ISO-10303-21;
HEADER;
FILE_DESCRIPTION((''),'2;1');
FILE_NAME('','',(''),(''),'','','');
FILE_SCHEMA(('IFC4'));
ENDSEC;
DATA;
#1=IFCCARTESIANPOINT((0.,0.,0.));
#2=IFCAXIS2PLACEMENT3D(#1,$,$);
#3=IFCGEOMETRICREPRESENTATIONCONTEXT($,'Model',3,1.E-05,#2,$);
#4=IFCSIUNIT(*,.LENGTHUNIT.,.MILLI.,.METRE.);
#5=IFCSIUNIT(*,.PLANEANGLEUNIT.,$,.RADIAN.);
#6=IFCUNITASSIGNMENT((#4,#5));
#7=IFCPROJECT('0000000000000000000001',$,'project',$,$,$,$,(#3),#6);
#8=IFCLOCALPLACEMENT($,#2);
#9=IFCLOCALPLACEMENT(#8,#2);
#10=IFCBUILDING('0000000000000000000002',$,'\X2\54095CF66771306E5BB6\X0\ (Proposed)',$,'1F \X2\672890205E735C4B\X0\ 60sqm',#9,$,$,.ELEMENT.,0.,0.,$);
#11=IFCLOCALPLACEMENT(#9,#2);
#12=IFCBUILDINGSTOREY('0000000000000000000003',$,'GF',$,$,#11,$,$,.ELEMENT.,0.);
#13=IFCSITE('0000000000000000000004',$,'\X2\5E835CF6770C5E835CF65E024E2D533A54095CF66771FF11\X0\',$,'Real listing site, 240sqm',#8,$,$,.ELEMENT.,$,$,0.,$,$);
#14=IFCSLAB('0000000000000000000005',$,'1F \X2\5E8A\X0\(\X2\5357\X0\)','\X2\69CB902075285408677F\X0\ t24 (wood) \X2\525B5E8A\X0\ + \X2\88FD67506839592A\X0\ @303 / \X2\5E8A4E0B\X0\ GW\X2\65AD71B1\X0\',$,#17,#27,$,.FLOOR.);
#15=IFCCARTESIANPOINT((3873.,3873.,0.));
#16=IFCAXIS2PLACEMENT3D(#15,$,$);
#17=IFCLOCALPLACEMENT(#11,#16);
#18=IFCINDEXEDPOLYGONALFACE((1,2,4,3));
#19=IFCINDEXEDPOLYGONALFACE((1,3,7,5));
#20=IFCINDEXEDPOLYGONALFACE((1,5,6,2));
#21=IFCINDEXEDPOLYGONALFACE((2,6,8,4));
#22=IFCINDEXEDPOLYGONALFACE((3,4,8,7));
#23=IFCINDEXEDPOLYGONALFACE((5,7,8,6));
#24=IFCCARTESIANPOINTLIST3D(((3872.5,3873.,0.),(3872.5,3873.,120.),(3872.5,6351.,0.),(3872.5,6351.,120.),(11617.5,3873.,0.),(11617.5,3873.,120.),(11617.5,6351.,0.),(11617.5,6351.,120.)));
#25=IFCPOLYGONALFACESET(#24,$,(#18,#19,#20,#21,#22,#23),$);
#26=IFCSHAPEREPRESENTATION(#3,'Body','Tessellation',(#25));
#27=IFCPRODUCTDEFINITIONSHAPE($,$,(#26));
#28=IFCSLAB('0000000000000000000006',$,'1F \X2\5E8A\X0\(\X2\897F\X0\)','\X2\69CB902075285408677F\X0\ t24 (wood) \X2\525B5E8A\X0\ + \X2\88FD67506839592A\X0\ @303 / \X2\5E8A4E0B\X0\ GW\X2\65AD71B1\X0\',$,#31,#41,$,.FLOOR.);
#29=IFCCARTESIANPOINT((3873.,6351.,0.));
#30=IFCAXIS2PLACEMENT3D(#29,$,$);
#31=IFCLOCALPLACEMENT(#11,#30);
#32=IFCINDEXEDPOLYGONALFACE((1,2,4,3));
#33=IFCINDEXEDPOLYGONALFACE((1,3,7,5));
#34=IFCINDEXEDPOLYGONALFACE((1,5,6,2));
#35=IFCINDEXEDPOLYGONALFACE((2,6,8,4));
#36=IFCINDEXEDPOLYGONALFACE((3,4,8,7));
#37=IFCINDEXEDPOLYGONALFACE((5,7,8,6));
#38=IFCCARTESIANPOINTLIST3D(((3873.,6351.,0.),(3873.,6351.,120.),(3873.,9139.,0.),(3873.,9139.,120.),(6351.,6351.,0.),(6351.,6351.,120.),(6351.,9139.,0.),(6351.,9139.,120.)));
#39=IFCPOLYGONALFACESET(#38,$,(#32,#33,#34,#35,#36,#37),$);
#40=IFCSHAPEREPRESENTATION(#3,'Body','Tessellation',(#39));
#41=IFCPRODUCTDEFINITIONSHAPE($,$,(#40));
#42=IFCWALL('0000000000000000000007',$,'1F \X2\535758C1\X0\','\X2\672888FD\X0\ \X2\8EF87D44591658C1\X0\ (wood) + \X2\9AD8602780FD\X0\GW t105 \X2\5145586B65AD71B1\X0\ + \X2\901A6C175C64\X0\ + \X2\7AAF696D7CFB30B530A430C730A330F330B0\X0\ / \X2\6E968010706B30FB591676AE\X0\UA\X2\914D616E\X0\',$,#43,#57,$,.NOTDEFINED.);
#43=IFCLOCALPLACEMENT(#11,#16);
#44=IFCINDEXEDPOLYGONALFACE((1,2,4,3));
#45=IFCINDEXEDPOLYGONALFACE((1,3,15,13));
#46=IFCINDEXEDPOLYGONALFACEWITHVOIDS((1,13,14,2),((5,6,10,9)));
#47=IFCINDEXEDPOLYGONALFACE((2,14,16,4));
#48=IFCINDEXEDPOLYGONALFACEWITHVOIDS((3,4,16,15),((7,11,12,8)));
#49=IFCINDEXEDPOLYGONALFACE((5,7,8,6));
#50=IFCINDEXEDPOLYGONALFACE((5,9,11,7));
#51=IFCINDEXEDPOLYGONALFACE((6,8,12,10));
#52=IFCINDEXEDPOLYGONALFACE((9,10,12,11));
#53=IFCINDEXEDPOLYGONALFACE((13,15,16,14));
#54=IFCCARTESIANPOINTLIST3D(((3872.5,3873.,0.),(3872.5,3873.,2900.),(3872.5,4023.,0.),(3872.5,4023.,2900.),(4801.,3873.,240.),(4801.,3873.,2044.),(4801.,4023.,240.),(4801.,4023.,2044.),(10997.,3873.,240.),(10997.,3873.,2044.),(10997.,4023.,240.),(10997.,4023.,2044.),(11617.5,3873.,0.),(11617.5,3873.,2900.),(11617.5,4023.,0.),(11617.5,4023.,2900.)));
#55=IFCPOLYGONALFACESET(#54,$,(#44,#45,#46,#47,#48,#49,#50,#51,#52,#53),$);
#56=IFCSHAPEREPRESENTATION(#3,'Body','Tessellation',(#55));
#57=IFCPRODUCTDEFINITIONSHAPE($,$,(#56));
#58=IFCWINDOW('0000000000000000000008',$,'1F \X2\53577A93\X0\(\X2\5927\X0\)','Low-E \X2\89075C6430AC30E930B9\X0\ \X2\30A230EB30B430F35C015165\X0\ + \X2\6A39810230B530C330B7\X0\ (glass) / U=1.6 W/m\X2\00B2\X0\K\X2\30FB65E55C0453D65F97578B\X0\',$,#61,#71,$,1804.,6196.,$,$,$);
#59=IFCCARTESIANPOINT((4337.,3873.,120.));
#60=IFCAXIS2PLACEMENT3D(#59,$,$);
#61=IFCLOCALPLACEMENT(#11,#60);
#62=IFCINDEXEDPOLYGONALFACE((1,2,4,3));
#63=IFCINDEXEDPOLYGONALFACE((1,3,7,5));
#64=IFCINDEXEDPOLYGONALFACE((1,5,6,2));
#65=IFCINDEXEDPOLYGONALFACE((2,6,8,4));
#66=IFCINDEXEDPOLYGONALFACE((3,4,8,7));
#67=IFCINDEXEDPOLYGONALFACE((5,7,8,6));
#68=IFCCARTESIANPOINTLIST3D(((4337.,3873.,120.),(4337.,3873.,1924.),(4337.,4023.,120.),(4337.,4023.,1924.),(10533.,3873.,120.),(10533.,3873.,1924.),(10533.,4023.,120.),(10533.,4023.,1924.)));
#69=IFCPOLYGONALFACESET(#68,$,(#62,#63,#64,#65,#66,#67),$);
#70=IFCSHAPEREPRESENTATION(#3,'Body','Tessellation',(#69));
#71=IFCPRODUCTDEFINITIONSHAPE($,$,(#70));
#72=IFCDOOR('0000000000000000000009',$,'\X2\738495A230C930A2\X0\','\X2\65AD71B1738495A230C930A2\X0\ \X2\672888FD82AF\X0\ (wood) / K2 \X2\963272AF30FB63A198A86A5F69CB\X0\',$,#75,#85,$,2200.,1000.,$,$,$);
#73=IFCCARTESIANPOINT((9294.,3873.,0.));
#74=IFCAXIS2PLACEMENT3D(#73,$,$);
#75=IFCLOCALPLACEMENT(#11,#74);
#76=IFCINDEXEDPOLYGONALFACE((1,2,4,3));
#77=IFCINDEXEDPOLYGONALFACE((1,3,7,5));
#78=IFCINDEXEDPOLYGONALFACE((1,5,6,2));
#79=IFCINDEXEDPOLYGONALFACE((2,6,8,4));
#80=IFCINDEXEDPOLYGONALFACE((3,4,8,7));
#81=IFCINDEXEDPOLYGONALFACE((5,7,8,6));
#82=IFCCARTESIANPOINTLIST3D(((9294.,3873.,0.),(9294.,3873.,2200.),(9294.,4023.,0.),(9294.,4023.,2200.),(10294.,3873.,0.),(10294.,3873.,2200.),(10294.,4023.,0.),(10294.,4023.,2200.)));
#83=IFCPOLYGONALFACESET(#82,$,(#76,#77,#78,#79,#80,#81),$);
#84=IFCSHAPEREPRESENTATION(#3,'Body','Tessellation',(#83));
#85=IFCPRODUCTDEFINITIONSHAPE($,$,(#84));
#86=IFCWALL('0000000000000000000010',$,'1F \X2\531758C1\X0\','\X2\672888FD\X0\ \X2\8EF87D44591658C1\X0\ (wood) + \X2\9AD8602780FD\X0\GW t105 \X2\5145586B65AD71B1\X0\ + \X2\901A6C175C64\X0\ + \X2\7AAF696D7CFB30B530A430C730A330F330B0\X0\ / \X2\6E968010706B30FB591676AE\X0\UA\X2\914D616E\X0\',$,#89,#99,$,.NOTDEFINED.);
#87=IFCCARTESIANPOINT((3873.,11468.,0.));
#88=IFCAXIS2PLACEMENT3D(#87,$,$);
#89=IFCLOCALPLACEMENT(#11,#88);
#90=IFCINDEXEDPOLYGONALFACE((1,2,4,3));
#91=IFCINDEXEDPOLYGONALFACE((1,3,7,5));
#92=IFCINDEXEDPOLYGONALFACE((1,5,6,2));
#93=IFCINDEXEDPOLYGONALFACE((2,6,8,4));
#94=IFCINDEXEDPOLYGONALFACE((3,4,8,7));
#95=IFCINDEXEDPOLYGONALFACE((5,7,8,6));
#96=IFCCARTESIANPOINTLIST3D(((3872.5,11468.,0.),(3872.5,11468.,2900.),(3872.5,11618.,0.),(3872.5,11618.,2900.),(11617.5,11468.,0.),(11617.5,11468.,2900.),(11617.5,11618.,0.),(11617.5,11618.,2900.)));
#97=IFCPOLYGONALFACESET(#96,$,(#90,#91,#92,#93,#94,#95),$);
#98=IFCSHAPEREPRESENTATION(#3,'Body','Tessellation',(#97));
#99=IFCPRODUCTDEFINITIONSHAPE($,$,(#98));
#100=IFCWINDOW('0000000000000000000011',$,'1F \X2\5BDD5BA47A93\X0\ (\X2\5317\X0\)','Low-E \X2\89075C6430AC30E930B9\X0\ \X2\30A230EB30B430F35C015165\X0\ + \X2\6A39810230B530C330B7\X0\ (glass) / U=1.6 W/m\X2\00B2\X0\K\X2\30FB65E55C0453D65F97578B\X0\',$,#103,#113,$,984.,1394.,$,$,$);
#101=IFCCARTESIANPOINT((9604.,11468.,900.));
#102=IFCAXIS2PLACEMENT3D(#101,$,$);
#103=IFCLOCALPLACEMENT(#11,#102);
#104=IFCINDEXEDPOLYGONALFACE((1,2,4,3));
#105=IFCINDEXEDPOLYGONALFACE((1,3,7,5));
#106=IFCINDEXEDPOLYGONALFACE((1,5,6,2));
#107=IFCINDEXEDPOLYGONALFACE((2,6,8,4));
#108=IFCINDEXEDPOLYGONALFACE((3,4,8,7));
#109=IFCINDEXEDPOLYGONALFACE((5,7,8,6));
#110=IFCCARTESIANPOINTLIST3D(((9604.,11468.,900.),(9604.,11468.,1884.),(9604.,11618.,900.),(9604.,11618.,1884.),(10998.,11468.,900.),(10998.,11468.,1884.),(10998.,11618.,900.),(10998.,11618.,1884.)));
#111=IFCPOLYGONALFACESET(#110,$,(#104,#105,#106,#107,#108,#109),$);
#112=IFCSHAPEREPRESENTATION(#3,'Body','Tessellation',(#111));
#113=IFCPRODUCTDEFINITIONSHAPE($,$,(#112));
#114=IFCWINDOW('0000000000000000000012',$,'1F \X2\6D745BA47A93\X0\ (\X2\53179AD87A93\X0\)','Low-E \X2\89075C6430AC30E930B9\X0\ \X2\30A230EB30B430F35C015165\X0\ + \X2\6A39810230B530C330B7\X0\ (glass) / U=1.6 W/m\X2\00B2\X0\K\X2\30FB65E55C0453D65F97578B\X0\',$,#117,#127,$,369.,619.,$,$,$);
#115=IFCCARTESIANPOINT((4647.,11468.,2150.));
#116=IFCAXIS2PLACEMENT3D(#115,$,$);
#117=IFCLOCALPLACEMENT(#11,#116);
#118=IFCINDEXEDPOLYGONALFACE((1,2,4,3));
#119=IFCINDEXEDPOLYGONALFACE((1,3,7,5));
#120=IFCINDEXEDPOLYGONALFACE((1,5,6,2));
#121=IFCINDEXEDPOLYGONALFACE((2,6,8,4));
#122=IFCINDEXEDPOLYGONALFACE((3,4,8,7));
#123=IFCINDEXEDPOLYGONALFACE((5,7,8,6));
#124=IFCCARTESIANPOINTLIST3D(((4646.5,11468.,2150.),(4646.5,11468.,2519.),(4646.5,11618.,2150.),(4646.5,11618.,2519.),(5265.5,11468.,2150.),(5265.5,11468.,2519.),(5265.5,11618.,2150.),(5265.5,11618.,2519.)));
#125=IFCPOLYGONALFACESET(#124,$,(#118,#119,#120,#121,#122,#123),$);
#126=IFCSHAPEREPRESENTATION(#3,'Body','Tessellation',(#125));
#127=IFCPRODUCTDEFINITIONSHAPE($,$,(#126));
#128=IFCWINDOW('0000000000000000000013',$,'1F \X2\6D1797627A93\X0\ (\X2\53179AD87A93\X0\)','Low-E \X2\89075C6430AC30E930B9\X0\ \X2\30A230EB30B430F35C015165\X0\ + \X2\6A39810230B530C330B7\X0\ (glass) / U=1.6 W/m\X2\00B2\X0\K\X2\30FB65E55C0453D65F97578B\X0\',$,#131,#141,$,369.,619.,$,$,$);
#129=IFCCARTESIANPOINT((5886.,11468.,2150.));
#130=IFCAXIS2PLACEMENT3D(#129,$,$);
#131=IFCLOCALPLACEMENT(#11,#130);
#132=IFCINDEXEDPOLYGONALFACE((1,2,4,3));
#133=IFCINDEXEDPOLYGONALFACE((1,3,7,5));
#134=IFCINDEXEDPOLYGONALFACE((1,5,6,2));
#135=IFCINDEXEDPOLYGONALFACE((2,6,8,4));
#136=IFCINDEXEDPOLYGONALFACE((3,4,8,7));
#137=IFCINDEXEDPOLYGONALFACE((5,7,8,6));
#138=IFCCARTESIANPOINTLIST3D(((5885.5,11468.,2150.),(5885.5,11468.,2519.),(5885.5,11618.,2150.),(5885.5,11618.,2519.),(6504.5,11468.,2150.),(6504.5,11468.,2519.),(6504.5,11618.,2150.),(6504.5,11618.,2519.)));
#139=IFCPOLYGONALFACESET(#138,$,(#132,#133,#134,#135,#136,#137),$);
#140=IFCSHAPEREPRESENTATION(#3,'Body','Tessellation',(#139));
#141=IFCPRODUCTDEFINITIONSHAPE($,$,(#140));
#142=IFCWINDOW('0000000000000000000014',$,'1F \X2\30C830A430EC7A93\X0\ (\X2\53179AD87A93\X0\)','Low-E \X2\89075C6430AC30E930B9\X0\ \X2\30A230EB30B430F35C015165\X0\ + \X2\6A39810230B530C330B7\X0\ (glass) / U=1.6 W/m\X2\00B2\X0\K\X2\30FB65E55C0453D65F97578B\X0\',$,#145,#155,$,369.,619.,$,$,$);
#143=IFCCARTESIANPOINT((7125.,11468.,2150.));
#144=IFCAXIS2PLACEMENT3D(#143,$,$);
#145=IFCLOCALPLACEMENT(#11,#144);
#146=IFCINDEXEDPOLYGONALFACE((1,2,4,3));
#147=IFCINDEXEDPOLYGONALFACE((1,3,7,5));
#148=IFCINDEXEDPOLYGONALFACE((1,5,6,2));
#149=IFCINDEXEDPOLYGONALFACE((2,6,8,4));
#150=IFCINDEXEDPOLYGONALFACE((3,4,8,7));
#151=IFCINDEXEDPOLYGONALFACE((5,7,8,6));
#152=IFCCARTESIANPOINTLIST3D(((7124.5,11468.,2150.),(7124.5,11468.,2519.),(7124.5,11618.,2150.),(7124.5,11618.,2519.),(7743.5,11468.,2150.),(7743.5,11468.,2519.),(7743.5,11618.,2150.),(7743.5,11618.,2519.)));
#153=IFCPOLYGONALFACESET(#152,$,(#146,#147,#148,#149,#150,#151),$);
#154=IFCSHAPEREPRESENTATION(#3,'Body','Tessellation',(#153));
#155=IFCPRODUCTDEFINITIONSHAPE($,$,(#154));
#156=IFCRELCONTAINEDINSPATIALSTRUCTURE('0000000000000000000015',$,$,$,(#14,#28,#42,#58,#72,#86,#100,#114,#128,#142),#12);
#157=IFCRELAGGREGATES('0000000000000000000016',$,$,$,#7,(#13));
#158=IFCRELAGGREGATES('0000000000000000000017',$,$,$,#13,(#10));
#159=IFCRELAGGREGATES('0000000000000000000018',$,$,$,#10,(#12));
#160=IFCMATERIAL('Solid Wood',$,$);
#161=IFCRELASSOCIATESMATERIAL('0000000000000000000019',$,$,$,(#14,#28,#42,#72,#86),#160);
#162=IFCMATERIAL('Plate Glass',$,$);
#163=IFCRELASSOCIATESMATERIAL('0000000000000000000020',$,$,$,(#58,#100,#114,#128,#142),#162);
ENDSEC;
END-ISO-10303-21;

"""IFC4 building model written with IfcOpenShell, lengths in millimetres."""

from ifc_helpers import new_model, si_unit, frame, frame_2d, origin, place, context, project, spatial, rectangle, extrude, material, element, fill, save


model = new_model("IFC4")

# Units and contexts
model_context = context("Model", 3, precision=1e-05, world=origin())
ifc_project = project(units=[si_unit("LENGTHUNIT", "METRE", prefix="MILLI"), si_unit("PLANEANGLEUNIT", "RADIAN")], contexts=[model_context])

# Site, building, storey
site_placement = place(None, origin())
site = spatial("IfcSite", under=ifc_project, at=site_placement, Name="広島県広島市中区吉島東１", ObjectType="Real listing site, 240sqm", CompositionType="ELEMENT", RefElevation=0.0)
building_placement = place(site_placement, origin())
building = spatial("IfcBuilding", under=site, at=building_placement, Name="吉島東の家 (Proposed)", ObjectType="1F 木造平屋 60sqm", CompositionType="ELEMENT", ElevationOfRefHeight=0.0, ElevationOfTerrain=0.0)
storey_placement = place(building_placement, origin())
storey = spatial("IfcBuildingStorey", under=building, at=storey_placement, Name="GF", CompositionType="ELEMENT", Elevation=0.0)

# Slabs
ifc_material_1 = material(Name="Solid Wood")
slab_1_placement = place(storey_placement, frame((3873.0, 3873.0, 0.0)))
element("IfcSlab", 1, at=slab_1_placement, inside=storey, material=ifc_material_1, Name="1F 床(南)", Description="構造用合板 t24 (wood) 剛床 + 製材根太 @303 / 床下 GW断熱", PredefinedType="FLOOR", context=model_context, shape_type="SweptSolid", body=[
    extrude(rectangle(XDim=7745.0, YDim=2478.0, at=frame_2d((3872.0, 1239.0))), frame((3873.0, 3873.0, 0.0)), (0.0, 0.0, 1.0), 120.0),
])
slab_2_placement = place(storey_placement, frame((3873.0, 6351.0, 0.0)))
element("IfcSlab", 2, at=slab_2_placement, inside=storey, material=ifc_material_1, Name="1F 床(西)", Description="構造用合板 t24 (wood) 剛床 + 製材根太 @303 / 床下 GW断熱", PredefinedType="FLOOR", context=model_context, shape_type="SweptSolid", body=[
    extrude(rectangle(XDim=2478.0, YDim=2788.0, at=frame_2d((1239.0, 1394.0))), frame((3873.0, 6351.0, 0.0)), (0.0, 0.0, 1.0), 120.0),
])

# Wall, openings, window, door
wall_1_placement = place(storey_placement, frame((3873.0, 3873.0, 0.0)))
wall_1 = element("IfcWall", 3, at=wall_1_placement, inside=storey, material=ifc_material_1, Name="1F 南壁", Description="木製 軸組外壁 (wood) + 高性能GW t105 充填断熱 + 通気層 + 窯業系サイディング / 準耐火・外皮UA配慮", PredefinedType="NOTDEFINED", context=model_context, shape_type="SweptSolid", body=[
    extrude(rectangle(XDim=7745.0, YDim=150.0, at=frame_2d((3872.0, 75.0))), frame((3873.0, 3873.0, 0.0)), (0.0, 0.0, 1.0), 2900.0),
])
opening_1_placement = place(storey_placement, frame((4337.0, 3873.0, 120.0)))
opening_1 = element("IfcOpeningElement", 4, at=opening_1_placement, cuts=wall_1, PredefinedType="NOTDEFINED", context=model_context, shape_type="SweptSolid", body=[
    extrude(rectangle(XDim=6196.0, YDim=150.0, at=frame_2d((3098.0, 75.0))), frame((4337.0, 3873.0, 120.0)), (0.0, 0.0, 1.0), 1804.0),
])
opening_2_placement = place(storey_placement, frame((9294.0, 3873.0, 0.0)))
opening_2 = element("IfcOpeningElement", 5, at=opening_2_placement, cuts=wall_1, PredefinedType="NOTDEFINED", context=model_context, shape_type="SweptSolid", body=[
    extrude(rectangle(XDim=1000.0, YDim=150.0, at=frame_2d((500.0, 75.0))), frame((9294.0, 3873.0, 0.0)), (0.0, 0.0, 1.0), 2200.0),
])
ifc_material_2 = material(Name="Plate Glass")
window_1_placement = place(storey_placement, frame((4337.0, 3873.0, 120.0)))
window_1 = element("IfcWindow", 6, at=window_1_placement, inside=storey, material=ifc_material_2, Name="1F 南窓(大)", Description="Low-E 複層ガラス アルゴン封入 + 樹脂サッシ (glass) / U=1.6 W/m²K・日射取得型", OverallHeight=1804.0, OverallWidth=6196.0, context=model_context, shape_type="SweptSolid", body=[
    extrude(rectangle(XDim=6196.0, YDim=150.0, at=frame_2d((3098.0, 75.0))), frame((4337.0, 3873.0, 120.0)), (0.0, 0.0, 1.0), 1804.0),
])
fill(opening_1, window_1)
door_1_placement = place(storey_placement, frame((9294.0, 3873.0, 0.0)))
door_1 = element("IfcDoor", 7, at=door_1_placement, inside=storey, material=ifc_material_1, Name="玄関ドア", Description="断熱玄関ドア 木製芯 (wood) / K2 防犯・採風機構", OverallHeight=2200.0, OverallWidth=1000.0, context=model_context, shape_type="SweptSolid", body=[
    extrude(rectangle(XDim=1000.0, YDim=150.0, at=frame_2d((500.0, 75.0))), frame((9294.0, 3873.0, 0.0)), (0.0, 0.0, 1.0), 2200.0),
])
fill(opening_2, door_1)

# Wall, openings, windows
wall_2_placement = place(storey_placement, frame((3873.0, 11468.0, 0.0)))
wall_2 = element("IfcWall", 8, at=wall_2_placement, inside=storey, material=ifc_material_1, Name="1F 北壁", Description="木製 軸組外壁 (wood) + 高性能GW t105 充填断熱 + 通気層 + 窯業系サイディング / 準耐火・外皮UA配慮", PredefinedType="NOTDEFINED", context=model_context, shape_type="SweptSolid", body=[
    extrude(rectangle(XDim=7745.0, YDim=150.0, at=frame_2d((3872.0, 75.0))), frame((3873.0, 11468.0, 0.0)), (0.0, 0.0, 1.0), 2900.0),
])
opening_3_placement = place(storey_placement, frame((9604.0, 11468.0, 900.0)))
opening_3 = element("IfcOpeningElement", 9, at=opening_3_placement, cuts=wall_2, PredefinedType="NOTDEFINED", context=model_context, shape_type="SweptSolid", body=[
    extrude(rectangle(XDim=1394.0, YDim=150.0, at=frame_2d((697.0, 75.0))), frame((9604.0, 11468.0, 900.0)), (0.0, 0.0, 1.0), 984.0),
])
opening_4_placement = place(storey_placement, frame((4647.0, 11468.0, 2150.0)))
opening_4 = element("IfcOpeningElement", 10, at=opening_4_placement, cuts=wall_2, PredefinedType="NOTDEFINED", context=model_context, shape_type="SweptSolid", body=[
    extrude(rectangle(XDim=619.0, YDim=150.0, at=frame_2d((309.0, 75.0))), frame((4647.0, 11468.0, 2150.0)), (0.0, 0.0, 1.0), 369.0),
])
opening_5_placement = place(storey_placement, frame((5886.0, 11468.0, 2150.0)))
opening_5 = element("IfcOpeningElement", 11, at=opening_5_placement, cuts=wall_2, PredefinedType="NOTDEFINED", context=model_context, shape_type="SweptSolid", body=[
    extrude(rectangle(XDim=619.0, YDim=150.0, at=frame_2d((309.0, 75.0))), frame((5886.0, 11468.0, 2150.0)), (0.0, 0.0, 1.0), 369.0),
])
opening_6_placement = place(storey_placement, frame((7125.0, 11468.0, 2150.0)))
opening_6 = element("IfcOpeningElement", 12, at=opening_6_placement, cuts=wall_2, PredefinedType="NOTDEFINED", context=model_context, shape_type="SweptSolid", body=[
    extrude(rectangle(XDim=619.0, YDim=150.0, at=frame_2d((309.0, 75.0))), frame((7125.0, 11468.0, 2150.0)), (0.0, 0.0, 1.0), 369.0),
])
window_2_placement = place(storey_placement, frame((9604.0, 11468.0, 900.0)))
window_2 = element("IfcWindow", 13, at=window_2_placement, inside=storey, material=ifc_material_2, Name="1F 寝室窓 (北)", Description="Low-E 複層ガラス アルゴン封入 + 樹脂サッシ (glass) / U=1.6 W/m²K・日射取得型", OverallHeight=984.0, OverallWidth=1394.0, context=model_context, shape_type="SweptSolid", body=[
    extrude(rectangle(XDim=1394.0, YDim=150.0, at=frame_2d((697.0, 75.0))), frame((9604.0, 11468.0, 900.0)), (0.0, 0.0, 1.0), 984.0),
])
fill(opening_3, window_2)
window_3_placement = place(storey_placement, frame((4647.0, 11468.0, 2150.0)))
window_3 = element("IfcWindow", 14, at=window_3_placement, inside=storey, material=ifc_material_2, Name="1F 浴室窓 (北高窓)", Description="Low-E 複層ガラス アルゴン封入 + 樹脂サッシ (glass) / U=1.6 W/m²K・日射取得型", OverallHeight=369.0, OverallWidth=619.0, context=model_context, shape_type="SweptSolid", body=[
    extrude(rectangle(XDim=619.0, YDim=150.0, at=frame_2d((309.0, 75.0))), frame((4647.0, 11468.0, 2150.0)), (0.0, 0.0, 1.0), 369.0),
])
fill(opening_4, window_3)
window_4_placement = place(storey_placement, frame((5886.0, 11468.0, 2150.0)))
window_4 = element("IfcWindow", 15, at=window_4_placement, inside=storey, material=ifc_material_2, Name="1F 洗面窓 (北高窓)", Description="Low-E 複層ガラス アルゴン封入 + 樹脂サッシ (glass) / U=1.6 W/m²K・日射取得型", OverallHeight=369.0, OverallWidth=619.0, context=model_context, shape_type="SweptSolid", body=[
    extrude(rectangle(XDim=619.0, YDim=150.0, at=frame_2d((309.0, 75.0))), frame((5886.0, 11468.0, 2150.0)), (0.0, 0.0, 1.0), 369.0),
])
fill(opening_5, window_4)
window_5_placement = place(storey_placement, frame((7125.0, 11468.0, 2150.0)))
window_5 = element("IfcWindow", 16, at=window_5_placement, inside=storey, material=ifc_material_2, Name="1F トイレ窓 (北高窓)", Description="Low-E 複層ガラス アルゴン封入 + 樹脂サッシ (glass) / U=1.6 W/m²K・日射取得型", OverallHeight=369.0, OverallWidth=619.0, context=model_context, shape_type="SweptSolid", body=[
    extrude(rectangle(XDim=619.0, YDim=150.0, at=frame_2d((309.0, 75.0))), frame((7125.0, 11468.0, 2150.0)), (0.0, 0.0, 1.0), 369.0),
])
fill(opening_6, window_5)

save(model, "model.ifc")
